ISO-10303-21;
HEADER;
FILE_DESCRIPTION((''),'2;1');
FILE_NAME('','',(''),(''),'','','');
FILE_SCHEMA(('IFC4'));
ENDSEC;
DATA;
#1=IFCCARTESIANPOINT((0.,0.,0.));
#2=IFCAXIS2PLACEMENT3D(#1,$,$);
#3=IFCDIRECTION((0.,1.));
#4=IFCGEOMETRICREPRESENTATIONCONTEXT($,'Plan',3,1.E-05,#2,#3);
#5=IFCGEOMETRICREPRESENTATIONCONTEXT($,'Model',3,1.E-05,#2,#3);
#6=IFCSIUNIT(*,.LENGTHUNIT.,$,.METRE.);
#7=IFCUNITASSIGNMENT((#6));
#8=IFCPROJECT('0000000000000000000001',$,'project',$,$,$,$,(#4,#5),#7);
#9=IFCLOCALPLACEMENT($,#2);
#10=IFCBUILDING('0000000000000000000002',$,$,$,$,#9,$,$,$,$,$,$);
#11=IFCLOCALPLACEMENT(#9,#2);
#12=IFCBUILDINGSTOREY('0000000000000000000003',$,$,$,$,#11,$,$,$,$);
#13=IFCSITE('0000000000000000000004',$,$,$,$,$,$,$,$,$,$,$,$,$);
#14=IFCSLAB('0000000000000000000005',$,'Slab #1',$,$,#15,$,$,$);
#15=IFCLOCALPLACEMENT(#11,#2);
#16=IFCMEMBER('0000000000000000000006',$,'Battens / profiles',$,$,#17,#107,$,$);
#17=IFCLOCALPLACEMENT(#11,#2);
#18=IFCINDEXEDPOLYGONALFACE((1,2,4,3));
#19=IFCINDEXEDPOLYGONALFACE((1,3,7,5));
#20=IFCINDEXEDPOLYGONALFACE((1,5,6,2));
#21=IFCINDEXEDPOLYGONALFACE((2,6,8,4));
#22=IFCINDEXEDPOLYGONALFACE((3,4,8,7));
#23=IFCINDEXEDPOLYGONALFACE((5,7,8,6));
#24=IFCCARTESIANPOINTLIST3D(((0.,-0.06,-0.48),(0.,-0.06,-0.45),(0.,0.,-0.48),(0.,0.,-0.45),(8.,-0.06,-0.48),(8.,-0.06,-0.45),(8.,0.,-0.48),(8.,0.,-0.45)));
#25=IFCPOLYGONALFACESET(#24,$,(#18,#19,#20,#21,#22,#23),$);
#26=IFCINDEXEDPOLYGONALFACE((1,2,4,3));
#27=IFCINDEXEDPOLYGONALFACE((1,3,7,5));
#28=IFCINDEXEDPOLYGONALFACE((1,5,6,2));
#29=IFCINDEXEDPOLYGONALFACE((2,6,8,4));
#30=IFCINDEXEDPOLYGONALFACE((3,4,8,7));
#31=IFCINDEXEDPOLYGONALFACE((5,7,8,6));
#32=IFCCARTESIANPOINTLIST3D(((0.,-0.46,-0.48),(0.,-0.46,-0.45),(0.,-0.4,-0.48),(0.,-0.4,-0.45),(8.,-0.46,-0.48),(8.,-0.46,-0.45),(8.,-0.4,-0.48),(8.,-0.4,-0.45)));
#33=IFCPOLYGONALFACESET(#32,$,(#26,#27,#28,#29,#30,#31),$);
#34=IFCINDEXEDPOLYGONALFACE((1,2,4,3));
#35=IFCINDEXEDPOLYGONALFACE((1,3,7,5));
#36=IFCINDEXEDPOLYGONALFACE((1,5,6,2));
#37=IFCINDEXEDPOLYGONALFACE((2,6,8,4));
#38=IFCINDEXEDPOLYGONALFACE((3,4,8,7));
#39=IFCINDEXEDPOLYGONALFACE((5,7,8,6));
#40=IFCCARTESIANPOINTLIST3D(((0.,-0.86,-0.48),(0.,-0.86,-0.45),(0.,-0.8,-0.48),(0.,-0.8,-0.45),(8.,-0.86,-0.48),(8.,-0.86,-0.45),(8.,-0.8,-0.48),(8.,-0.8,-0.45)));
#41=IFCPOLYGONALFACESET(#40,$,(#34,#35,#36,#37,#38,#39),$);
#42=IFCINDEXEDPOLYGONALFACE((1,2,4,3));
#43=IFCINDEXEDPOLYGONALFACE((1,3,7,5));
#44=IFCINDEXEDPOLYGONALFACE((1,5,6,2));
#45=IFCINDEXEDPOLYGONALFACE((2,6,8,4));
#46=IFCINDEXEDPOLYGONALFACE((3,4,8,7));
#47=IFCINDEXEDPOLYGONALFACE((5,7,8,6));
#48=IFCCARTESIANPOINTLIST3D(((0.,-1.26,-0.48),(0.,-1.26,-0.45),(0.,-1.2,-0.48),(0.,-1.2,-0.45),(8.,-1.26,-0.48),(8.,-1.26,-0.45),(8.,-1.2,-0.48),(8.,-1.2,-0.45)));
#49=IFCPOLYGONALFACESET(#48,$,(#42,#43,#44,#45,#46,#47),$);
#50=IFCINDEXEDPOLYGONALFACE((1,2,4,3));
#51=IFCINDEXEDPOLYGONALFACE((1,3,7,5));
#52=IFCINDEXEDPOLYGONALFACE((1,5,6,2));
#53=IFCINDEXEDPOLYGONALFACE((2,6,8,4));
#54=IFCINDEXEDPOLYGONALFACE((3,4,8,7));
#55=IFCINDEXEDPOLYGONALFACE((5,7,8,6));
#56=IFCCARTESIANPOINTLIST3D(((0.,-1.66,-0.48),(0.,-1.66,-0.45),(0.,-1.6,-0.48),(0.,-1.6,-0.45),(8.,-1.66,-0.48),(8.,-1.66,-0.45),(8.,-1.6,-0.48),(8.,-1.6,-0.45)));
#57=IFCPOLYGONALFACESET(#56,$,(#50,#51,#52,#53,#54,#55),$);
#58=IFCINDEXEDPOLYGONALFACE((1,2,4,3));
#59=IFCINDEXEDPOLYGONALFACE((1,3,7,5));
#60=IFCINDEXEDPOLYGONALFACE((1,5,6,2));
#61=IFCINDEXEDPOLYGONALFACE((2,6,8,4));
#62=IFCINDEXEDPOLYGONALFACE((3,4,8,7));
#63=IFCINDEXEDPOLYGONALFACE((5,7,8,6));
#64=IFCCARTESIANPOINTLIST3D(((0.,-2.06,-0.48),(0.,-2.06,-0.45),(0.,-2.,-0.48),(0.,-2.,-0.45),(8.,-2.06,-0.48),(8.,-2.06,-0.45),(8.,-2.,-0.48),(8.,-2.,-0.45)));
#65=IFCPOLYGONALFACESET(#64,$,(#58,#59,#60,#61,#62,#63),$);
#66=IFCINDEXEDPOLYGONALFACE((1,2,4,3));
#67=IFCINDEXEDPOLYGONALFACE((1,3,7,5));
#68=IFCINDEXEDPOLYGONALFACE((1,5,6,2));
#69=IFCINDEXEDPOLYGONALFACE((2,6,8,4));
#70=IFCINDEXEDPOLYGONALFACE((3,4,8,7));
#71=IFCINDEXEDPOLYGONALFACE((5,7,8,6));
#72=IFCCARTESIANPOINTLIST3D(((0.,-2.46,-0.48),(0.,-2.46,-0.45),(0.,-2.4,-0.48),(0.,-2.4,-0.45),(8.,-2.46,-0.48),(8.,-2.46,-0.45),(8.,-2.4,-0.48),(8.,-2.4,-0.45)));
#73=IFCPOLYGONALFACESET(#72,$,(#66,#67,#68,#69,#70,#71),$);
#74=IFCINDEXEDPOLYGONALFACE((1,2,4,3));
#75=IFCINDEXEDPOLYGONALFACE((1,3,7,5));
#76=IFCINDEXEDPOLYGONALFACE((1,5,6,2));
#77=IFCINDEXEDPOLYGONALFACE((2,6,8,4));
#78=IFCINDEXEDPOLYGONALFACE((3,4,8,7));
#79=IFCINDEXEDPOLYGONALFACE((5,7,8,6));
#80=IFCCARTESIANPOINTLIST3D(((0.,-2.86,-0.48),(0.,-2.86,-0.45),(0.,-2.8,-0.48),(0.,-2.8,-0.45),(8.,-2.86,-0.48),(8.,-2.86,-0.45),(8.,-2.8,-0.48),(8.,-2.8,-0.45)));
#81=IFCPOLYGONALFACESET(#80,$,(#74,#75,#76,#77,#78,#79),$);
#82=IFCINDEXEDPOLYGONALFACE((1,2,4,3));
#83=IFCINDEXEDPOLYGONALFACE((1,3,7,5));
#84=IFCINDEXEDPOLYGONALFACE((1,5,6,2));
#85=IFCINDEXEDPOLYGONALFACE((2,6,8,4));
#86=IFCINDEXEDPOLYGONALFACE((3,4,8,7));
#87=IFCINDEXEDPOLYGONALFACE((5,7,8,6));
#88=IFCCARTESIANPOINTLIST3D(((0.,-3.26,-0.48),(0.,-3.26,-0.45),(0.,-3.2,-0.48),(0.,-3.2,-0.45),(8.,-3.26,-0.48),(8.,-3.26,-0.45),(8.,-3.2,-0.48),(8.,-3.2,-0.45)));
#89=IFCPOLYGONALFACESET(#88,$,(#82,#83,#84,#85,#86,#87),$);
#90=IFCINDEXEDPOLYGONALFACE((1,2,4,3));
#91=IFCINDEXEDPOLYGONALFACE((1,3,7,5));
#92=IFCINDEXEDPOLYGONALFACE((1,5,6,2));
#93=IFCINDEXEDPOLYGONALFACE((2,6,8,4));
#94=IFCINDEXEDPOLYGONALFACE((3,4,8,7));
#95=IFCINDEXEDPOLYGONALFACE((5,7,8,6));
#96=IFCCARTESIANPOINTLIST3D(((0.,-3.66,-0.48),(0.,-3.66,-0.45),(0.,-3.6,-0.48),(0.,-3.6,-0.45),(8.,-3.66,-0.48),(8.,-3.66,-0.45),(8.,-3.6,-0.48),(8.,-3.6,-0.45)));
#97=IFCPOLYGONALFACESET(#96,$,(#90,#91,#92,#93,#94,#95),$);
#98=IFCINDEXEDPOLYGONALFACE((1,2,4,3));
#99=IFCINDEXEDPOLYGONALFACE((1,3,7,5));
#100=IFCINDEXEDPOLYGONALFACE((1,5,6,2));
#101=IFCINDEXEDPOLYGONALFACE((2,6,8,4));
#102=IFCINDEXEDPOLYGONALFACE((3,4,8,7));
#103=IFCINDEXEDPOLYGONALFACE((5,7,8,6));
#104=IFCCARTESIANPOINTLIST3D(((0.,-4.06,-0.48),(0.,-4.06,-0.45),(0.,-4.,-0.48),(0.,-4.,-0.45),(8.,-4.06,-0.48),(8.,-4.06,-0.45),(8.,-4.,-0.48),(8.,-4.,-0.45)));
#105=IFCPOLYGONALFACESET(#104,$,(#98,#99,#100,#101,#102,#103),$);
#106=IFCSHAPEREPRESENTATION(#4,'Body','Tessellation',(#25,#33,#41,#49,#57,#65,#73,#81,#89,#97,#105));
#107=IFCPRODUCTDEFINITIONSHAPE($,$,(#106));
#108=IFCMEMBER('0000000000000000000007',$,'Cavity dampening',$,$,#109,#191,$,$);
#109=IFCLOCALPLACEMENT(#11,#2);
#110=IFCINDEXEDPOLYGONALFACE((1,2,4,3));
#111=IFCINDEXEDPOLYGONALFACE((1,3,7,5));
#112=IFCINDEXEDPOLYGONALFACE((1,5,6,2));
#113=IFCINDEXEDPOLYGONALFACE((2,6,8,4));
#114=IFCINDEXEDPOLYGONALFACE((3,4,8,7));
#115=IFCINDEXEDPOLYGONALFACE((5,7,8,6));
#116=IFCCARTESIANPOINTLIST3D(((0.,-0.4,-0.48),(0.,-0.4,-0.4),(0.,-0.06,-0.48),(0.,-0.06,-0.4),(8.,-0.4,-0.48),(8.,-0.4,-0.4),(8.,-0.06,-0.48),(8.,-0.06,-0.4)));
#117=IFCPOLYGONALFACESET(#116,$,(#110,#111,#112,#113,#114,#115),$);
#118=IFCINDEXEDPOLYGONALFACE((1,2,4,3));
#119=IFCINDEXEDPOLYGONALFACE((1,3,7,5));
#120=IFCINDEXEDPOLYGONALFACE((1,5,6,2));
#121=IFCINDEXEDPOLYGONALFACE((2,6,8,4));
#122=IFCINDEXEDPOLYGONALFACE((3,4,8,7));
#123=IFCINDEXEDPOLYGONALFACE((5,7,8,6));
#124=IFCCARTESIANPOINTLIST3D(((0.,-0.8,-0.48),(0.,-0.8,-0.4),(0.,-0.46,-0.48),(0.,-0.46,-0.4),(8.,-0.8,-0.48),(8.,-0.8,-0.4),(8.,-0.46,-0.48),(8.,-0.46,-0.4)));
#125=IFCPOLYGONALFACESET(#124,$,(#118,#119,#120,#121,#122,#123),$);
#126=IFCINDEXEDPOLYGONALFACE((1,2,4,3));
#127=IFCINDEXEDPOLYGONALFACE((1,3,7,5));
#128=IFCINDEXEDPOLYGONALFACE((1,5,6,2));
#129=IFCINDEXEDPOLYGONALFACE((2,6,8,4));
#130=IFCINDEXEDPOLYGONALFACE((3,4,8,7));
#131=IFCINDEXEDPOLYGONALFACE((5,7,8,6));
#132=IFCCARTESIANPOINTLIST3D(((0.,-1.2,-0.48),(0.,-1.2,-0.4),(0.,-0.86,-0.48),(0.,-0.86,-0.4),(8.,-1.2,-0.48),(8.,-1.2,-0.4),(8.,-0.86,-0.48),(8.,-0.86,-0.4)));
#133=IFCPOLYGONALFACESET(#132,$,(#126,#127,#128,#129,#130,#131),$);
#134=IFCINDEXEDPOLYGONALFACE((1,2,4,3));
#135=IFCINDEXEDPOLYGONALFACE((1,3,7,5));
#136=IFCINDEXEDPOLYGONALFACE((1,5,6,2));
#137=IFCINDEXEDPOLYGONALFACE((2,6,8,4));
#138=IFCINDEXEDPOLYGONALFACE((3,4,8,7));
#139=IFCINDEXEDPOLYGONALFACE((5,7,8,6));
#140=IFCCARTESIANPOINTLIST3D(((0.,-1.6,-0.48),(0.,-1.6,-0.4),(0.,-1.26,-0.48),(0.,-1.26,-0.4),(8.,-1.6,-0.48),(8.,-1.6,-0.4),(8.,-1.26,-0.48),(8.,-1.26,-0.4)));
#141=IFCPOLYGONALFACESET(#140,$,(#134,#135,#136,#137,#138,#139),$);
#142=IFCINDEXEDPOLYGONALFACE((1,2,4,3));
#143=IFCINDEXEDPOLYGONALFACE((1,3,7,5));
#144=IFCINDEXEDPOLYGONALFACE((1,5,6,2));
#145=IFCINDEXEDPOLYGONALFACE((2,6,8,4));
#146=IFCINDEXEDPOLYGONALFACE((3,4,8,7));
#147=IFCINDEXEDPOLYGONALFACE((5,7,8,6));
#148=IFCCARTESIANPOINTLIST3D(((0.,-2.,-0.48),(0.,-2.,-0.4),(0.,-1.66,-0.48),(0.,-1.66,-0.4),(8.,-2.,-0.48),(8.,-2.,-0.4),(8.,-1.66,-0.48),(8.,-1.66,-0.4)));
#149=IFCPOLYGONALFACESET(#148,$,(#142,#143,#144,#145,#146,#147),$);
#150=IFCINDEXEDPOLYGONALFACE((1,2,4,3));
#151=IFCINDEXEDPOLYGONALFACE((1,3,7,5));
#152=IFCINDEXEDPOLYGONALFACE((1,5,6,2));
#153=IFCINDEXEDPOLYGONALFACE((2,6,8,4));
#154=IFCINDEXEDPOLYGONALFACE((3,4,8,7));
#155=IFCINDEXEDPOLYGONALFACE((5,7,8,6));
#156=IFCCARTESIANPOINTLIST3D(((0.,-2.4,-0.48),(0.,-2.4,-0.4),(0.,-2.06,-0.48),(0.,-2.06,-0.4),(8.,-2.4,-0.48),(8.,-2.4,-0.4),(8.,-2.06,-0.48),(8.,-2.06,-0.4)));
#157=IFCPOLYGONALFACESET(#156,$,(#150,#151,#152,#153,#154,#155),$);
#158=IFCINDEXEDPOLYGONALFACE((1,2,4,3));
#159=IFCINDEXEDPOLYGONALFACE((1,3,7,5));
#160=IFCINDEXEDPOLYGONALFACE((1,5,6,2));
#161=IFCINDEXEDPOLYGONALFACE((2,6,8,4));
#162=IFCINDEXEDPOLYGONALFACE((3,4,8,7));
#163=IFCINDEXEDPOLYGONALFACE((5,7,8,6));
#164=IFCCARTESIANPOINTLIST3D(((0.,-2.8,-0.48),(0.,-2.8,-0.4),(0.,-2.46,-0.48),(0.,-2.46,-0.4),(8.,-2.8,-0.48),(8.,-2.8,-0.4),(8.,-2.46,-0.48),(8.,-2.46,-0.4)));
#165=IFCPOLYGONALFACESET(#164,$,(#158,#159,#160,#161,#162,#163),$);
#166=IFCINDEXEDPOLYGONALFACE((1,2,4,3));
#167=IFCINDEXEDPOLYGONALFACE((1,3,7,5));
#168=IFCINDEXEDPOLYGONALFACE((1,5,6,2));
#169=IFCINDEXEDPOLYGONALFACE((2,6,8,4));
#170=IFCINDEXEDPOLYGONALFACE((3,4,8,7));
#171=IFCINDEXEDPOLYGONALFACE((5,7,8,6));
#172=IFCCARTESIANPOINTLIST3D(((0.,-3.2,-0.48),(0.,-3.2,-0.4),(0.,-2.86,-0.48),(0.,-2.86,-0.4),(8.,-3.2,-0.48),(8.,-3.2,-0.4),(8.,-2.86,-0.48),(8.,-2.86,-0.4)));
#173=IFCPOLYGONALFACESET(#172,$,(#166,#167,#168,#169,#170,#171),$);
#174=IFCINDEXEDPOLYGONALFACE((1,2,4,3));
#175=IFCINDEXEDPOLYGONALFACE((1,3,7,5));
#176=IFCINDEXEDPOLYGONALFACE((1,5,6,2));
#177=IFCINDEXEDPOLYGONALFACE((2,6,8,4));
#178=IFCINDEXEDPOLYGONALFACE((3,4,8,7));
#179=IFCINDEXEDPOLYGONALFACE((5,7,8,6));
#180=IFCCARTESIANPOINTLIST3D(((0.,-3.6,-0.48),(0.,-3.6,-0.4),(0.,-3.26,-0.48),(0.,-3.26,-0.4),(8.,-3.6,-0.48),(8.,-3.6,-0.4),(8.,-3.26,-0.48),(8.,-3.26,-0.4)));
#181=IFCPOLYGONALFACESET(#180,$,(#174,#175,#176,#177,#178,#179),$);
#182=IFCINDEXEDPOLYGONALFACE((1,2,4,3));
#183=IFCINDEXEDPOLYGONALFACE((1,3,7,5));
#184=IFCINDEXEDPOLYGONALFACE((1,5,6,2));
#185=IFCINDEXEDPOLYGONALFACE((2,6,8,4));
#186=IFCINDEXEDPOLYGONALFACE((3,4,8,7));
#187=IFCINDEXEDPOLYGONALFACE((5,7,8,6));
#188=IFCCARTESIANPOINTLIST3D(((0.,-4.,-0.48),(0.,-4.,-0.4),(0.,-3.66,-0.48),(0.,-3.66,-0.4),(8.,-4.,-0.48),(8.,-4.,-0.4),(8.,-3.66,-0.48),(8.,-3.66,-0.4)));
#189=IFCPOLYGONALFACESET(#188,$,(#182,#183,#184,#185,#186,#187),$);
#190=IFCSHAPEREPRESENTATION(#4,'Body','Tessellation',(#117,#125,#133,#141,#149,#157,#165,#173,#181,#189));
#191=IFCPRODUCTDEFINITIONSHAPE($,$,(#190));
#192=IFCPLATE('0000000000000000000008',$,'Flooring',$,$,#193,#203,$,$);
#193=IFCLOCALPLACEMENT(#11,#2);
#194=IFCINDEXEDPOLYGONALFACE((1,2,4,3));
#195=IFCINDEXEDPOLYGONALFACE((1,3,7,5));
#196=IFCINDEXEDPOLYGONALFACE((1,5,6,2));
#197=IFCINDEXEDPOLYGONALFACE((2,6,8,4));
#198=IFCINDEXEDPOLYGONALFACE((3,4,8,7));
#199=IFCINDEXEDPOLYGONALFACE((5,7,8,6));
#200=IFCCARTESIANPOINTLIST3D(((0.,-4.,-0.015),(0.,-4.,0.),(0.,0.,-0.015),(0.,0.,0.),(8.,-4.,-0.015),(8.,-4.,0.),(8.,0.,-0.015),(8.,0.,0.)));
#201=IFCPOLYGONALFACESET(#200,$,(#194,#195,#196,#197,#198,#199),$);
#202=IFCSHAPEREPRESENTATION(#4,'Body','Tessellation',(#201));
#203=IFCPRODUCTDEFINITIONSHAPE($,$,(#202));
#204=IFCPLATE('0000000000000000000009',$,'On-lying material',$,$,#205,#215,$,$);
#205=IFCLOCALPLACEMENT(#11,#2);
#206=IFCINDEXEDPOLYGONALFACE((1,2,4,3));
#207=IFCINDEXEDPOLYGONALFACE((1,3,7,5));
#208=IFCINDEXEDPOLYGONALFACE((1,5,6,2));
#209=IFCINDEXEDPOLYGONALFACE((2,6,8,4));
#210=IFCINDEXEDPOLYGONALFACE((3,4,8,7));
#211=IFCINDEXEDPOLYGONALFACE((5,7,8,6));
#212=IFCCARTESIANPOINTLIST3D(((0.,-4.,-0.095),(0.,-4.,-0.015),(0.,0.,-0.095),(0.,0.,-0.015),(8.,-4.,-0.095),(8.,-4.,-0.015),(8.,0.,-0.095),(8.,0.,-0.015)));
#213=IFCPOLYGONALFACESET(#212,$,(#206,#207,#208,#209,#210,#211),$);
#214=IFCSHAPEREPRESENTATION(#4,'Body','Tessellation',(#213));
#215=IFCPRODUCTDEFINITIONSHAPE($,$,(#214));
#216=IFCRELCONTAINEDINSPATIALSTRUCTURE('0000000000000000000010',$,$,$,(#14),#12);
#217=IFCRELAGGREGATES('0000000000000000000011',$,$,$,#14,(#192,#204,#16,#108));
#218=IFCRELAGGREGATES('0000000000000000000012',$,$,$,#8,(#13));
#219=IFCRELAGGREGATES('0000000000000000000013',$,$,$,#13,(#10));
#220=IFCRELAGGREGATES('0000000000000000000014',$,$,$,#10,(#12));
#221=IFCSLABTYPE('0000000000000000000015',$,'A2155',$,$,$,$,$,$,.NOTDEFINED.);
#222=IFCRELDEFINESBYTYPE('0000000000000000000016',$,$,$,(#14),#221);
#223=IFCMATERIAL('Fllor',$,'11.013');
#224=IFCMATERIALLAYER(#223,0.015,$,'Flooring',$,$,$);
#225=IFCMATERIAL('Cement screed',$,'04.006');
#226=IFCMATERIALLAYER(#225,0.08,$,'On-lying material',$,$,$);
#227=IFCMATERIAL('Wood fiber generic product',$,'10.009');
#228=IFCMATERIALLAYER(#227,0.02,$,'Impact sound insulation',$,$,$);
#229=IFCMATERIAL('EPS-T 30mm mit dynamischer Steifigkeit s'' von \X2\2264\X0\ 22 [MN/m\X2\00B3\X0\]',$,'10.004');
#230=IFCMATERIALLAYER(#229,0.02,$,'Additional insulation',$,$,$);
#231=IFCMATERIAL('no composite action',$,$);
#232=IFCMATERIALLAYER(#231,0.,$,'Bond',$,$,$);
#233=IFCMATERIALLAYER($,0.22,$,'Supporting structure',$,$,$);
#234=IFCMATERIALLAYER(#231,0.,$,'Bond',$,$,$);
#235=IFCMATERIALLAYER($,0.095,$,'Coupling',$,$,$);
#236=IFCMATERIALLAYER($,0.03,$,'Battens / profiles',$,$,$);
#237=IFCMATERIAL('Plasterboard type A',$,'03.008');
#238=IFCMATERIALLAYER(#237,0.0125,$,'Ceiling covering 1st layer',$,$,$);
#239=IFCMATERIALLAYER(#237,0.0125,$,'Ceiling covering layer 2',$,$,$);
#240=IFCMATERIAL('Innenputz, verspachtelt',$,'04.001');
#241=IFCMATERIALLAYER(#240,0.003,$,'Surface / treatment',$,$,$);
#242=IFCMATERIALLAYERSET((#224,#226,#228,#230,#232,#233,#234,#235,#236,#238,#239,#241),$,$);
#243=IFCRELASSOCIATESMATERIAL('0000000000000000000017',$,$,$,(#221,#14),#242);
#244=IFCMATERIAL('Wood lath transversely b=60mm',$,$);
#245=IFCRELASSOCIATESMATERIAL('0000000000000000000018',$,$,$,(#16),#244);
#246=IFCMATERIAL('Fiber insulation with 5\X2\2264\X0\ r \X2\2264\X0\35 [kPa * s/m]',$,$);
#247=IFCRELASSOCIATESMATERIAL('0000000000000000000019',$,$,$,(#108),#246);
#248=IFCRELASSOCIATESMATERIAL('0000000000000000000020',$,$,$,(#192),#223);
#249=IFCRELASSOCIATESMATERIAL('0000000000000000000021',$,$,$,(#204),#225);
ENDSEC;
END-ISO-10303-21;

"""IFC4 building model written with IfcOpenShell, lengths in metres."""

from ifc_helpers import new_model, si_unit, direction, frame, frame_2d, origin, origin_with_axes, place, context, project, spatial, rectangle, extrude, material, layer, layer_set, type_object, element, aggregate, save


model = new_model("IFC4")

# Units and contexts
plan_context = context("Plan", 3, precision=1e-05, world=origin(), true_north=direction((0.0, 1.0)))
model_context = context("Model", 3, precision=1e-05, world=origin(), true_north=direction((0.0, 1.0)))
ifc_project = project(units=[si_unit("LENGTHUNIT", "METRE")], contexts=[plan_context, model_context])

# Site, building, storey
site = spatial("IfcSite", under=ifc_project)
building_placement = place(None, origin())
building = spatial("IfcBuilding", under=site, at=building_placement)
storey_placement = place(building_placement, origin())
storey = spatial("IfcBuildingStorey", under=building, at=storey_placement)

# Slab, members, plates
ifc_material_1 = material(Name="Fllor", Category="11.013")
ifc_layer_1 = layer(ifc_material_1, 0.015, Name="Flooring")
ifc_material_2 = material(Name="Cement screed", Category="04.006")
ifc_layer_2 = layer(ifc_material_2, 0.08, Name="On-lying material")
ifc_material_3 = material(Name="Wood fiber generic product", Category="10.009")
ifc_layer_3 = layer(ifc_material_3, 0.02, Name="Impact sound insulation")
ifc_material_4 = material(Name="EPS-T 30mm mit dynamischer Steifigkeit s' von ≤ 22 [MN/m³]", Category="10.004")
ifc_layer_4 = layer(ifc_material_4, 0.02, Name="Additional insulation")
ifc_material_5 = material(Name="no composite action")
ifc_layer_5 = layer(ifc_material_5, 0.0, Name="Bond")
ifc_layer_6 = layer(None, 0.22, Name="Supporting structure")
ifc_layer_7 = layer(ifc_material_5, 0.0, Name="Bond")
ifc_layer_8 = layer(None, 0.095, Name="Coupling")
ifc_layer_9 = layer(None, 0.03, Name="Battens / profiles")
ifc_material_6 = material(Name="Plasterboard type A", Category="03.008")
ifc_layer_10 = layer(ifc_material_6, 0.0125, Name="Ceiling covering 1st layer")
ifc_layer_11 = layer(ifc_material_6, 0.0125, Name="Ceiling covering layer 2")
ifc_material_7 = material(Name="Innenputz, verspachtelt", Category="04.001")
ifc_layer_12 = layer(ifc_material_7, 0.003, Name="Surface / treatment")
ifc_layer_set = layer_set([ifc_layer_1, ifc_layer_2, ifc_layer_3, ifc_layer_4, ifc_layer_5, ifc_layer_6, ifc_layer_7, ifc_layer_8, ifc_layer_9, ifc_layer_10, ifc_layer_11, ifc_layer_12])
slab_type = type_object("IfcSlabType", Name="A2155", PredefinedType="NOTDEFINED", material=ifc_layer_set)
slab_placement = place(None, frame((0.0, 0.0, 0.0), z_axis=(0.0, 0.0, -1.0), x_axis=(1.0, 0.0, 0.0)))
slab = element("IfcSlab", 1, at=slab_placement, inside=storey, type_object=slab_type, material=ifc_layer_set, Name="Slab #1")
ifc_material_8 = material(Name="Wood lath transversely b=60mm")
member_1_placement = place(slab_placement, origin())
member_1 = element("IfcMember", 2, at=member_1_placement, material=ifc_material_8, Name="Battens / profiles", context=plan_context, shape_type="SweptSolid", body=[
    extrude(rectangle(XDim=0.06, YDim=0.03, at=frame_2d((0.03, 0.015), x_axis=(1.0, 0.0))), frame((0.0, 0.0, 0.45), z_axis=(1.0, 0.0, 0.0), x_axis=(0.0, 1.0, 0.0)), (0.0, 0.0, 1.0), 8.0),
    extrude(rectangle(XDim=0.06, YDim=0.03, at=frame_2d((0.03, 0.015), x_axis=(1.0, 0.0))), frame((0.0, 0.4, 0.45), z_axis=(1.0, 0.0, 0.0), x_axis=(0.0, 1.0, 0.0)), (0.0, 0.0, 1.0), 8.0),
    extrude(rectangle(XDim=0.06, YDim=0.03, at=frame_2d((0.03, 0.015), x_axis=(1.0, 0.0))), frame((0.0, 0.8, 0.45), z_axis=(1.0, 0.0, 0.0), x_axis=(0.0, 1.0, 0.0)), (0.0, 0.0, 1.0), 8.0),
    extrude(rectangle(XDim=0.06, YDim=0.03, at=frame_2d((0.03, 0.015), x_axis=(1.0, 0.0))), frame((0.0, 1.2, 0.45), z_axis=(1.0, 0.0, 0.0), x_axis=(0.0, 1.0, 0.0)), (0.0, 0.0, 1.0), 8.0),
    extrude(rectangle(XDim=0.06, YDim=0.03, at=frame_2d((0.03, 0.015), x_axis=(1.0, 0.0))), frame((0.0, 1.6, 0.45), z_axis=(1.0, 0.0, 0.0), x_axis=(0.0, 1.0, 0.0)), (0.0, 0.0, 1.0), 8.0),
    extrude(rectangle(XDim=0.06, YDim=0.03, at=frame_2d((0.03, 0.015), x_axis=(1.0, 0.0))), frame((0.0, 2.0, 0.45), z_axis=(1.0, 0.0, 0.0), x_axis=(0.0, 1.0, 0.0)), (0.0, 0.0, 1.0), 8.0),
    extrude(rectangle(XDim=0.06, YDim=0.03, at=frame_2d((0.03, 0.015), x_axis=(1.0, 0.0))), frame((0.0, 2.4, 0.45), z_axis=(1.0, 0.0, 0.0), x_axis=(0.0, 1.0, 0.0)), (0.0, 0.0, 1.0), 8.0),
    extrude(rectangle(XDim=0.06, YDim=0.03, at=frame_2d((0.03, 0.015), x_axis=(1.0, 0.0))), frame((0.0, 2.8, 0.45), z_axis=(1.0, 0.0, 0.0), x_axis=(0.0, 1.0, 0.0)), (0.0, 0.0, 1.0), 8.0),
    extrude(rectangle(XDim=0.06, YDim=0.03, at=frame_2d((0.03, 0.015), x_axis=(1.0, 0.0))), frame((0.0, 3.2, 0.45), z_axis=(1.0, 0.0, 0.0), x_axis=(0.0, 1.0, 0.0)), (0.0, 0.0, 1.0), 8.0),
    extrude(rectangle(XDim=0.06, YDim=0.03, at=frame_2d((0.03, 0.015), x_axis=(1.0, 0.0))), frame((0.0, 3.6, 0.45), z_axis=(1.0, 0.0, 0.0), x_axis=(0.0, 1.0, 0.0)), (0.0, 0.0, 1.0), 8.0),
    extrude(rectangle(XDim=0.06, YDim=0.03, at=frame_2d((0.03, 0.015), x_axis=(1.0, 0.0))), frame((0.0, 4.0, 0.45), z_axis=(1.0, 0.0, 0.0), x_axis=(0.0, 1.0, 0.0)), (0.0, 0.0, 1.0), 8.0),
])
ifc_material_9 = material(Name="Fiber insulation with 5≤ r ≤35 [kPa * s/m]")
member_2_placement = place(slab_placement, origin())
member_2 = element("IfcMember", 3, at=member_2_placement, material=ifc_material_9, Name="Cavity dampening", context=plan_context, shape_type="SweptSolid", body=[
    extrude(rectangle(XDim=0.34, YDim=0.08, at=frame_2d((0.17, 0.04), x_axis=(1.0, 0.0))), frame((0.0, 0.06, 0.4), z_axis=(1.0, 0.0, 0.0), x_axis=(0.0, 1.0, 0.0)), (0.0, 0.0, 1.0), 8.0),
    extrude(rectangle(XDim=0.34, YDim=0.08, at=frame_2d((0.17, 0.04), x_axis=(1.0, 0.0))), frame((0.0, 0.46, 0.4), z_axis=(1.0, 0.0, 0.0), x_axis=(0.0, 1.0, 0.0)), (0.0, 0.0, 1.0), 8.0),
    extrude(rectangle(XDim=0.34, YDim=0.08, at=frame_2d((0.17, 0.04), x_axis=(1.0, 0.0))), frame((0.0, 0.86, 0.4), z_axis=(1.0, 0.0, 0.0), x_axis=(0.0, 1.0, 0.0)), (0.0, 0.0, 1.0), 8.0),
    extrude(rectangle(XDim=0.34, YDim=0.08, at=frame_2d((0.17, 0.04), x_axis=(1.0, 0.0))), frame((0.0, 1.26, 0.4), z_axis=(1.0, 0.0, 0.0), x_axis=(0.0, 1.0, 0.0)), (0.0, 0.0, 1.0), 8.0),
    extrude(rectangle(XDim=0.34, YDim=0.08, at=frame_2d((0.17, 0.04), x_axis=(1.0, 0.0))), frame((0.0, 1.66, 0.4), z_axis=(1.0, 0.0, 0.0), x_axis=(0.0, 1.0, 0.0)), (0.0, 0.0, 1.0), 8.0),
    extrude(rectangle(XDim=0.34, YDim=0.08, at=frame_2d((0.17, 0.04), x_axis=(1.0, 0.0))), frame((0.0, 2.06, 0.4), z_axis=(1.0, 0.0, 0.0), x_axis=(0.0, 1.0, 0.0)), (0.0, 0.0, 1.0), 8.0),
    extrude(rectangle(XDim=0.34, YDim=0.08, at=frame_2d((0.17, 0.04), x_axis=(1.0, 0.0))), frame((0.0, 2.46, 0.4), z_axis=(1.0, 0.0, 0.0), x_axis=(0.0, 1.0, 0.0)), (0.0, 0.0, 1.0), 8.0),
    extrude(rectangle(XDim=0.34, YDim=0.08, at=frame_2d((0.17, 0.04), x_axis=(1.0, 0.0))), frame((0.0, 2.86, 0.4), z_axis=(1.0, 0.0, 0.0), x_axis=(0.0, 1.0, 0.0)), (0.0, 0.0, 1.0), 8.0),
    extrude(rectangle(XDim=0.34, YDim=0.08, at=frame_2d((0.17, 0.04), x_axis=(1.0, 0.0))), frame((0.0, 3.26, 0.4), z_axis=(1.0, 0.0, 0.0), x_axis=(0.0, 1.0, 0.0)), (0.0, 0.0, 1.0), 8.0),
    extrude(rectangle(XDim=0.34, YDim=0.08, at=frame_2d((0.17, 0.04), x_axis=(1.0, 0.0))), frame((0.0, 3.66, 0.4), z_axis=(1.0, 0.0, 0.0), x_axis=(0.0, 1.0, 0.0)), (0.0, 0.0, 1.0), 8.0),
])
plate_1_placement = place(slab_placement, origin())
plate_1 = element("IfcPlate", 4, at=plate_1_placement, material=ifc_material_1, Name="Flooring", context=plan_context, shape_type="SweptSolid", body=[
    extrude(rectangle(XDim=8.0, YDim=4.0, at=frame_2d((4.0, 2.0), x_axis=(1.0, 0.0))), origin_with_axes(), (0.0, 0.0, 1.0), 0.015),
])
plate_2_placement = place(slab_placement, origin())
plate_2 = element("IfcPlate", 5, at=plate_2_placement, material=ifc_material_2, Name="On-lying material", context=plan_context, shape_type="SweptSolid", body=[
    extrude(rectangle(XDim=8.0, YDim=4.0, at=frame_2d((4.0, 2.0), x_axis=(1.0, 0.0))), frame((0.0, 0.0, 0.015), z_axis=(0.0, 0.0, 1.0), x_axis=(1.0, 0.0, 0.0)), (0.0, 0.0, 1.0), 0.08),
])
aggregate(slab, [plate_1, plate_2, member_1, member_2])

save(model, "model.ifc")
